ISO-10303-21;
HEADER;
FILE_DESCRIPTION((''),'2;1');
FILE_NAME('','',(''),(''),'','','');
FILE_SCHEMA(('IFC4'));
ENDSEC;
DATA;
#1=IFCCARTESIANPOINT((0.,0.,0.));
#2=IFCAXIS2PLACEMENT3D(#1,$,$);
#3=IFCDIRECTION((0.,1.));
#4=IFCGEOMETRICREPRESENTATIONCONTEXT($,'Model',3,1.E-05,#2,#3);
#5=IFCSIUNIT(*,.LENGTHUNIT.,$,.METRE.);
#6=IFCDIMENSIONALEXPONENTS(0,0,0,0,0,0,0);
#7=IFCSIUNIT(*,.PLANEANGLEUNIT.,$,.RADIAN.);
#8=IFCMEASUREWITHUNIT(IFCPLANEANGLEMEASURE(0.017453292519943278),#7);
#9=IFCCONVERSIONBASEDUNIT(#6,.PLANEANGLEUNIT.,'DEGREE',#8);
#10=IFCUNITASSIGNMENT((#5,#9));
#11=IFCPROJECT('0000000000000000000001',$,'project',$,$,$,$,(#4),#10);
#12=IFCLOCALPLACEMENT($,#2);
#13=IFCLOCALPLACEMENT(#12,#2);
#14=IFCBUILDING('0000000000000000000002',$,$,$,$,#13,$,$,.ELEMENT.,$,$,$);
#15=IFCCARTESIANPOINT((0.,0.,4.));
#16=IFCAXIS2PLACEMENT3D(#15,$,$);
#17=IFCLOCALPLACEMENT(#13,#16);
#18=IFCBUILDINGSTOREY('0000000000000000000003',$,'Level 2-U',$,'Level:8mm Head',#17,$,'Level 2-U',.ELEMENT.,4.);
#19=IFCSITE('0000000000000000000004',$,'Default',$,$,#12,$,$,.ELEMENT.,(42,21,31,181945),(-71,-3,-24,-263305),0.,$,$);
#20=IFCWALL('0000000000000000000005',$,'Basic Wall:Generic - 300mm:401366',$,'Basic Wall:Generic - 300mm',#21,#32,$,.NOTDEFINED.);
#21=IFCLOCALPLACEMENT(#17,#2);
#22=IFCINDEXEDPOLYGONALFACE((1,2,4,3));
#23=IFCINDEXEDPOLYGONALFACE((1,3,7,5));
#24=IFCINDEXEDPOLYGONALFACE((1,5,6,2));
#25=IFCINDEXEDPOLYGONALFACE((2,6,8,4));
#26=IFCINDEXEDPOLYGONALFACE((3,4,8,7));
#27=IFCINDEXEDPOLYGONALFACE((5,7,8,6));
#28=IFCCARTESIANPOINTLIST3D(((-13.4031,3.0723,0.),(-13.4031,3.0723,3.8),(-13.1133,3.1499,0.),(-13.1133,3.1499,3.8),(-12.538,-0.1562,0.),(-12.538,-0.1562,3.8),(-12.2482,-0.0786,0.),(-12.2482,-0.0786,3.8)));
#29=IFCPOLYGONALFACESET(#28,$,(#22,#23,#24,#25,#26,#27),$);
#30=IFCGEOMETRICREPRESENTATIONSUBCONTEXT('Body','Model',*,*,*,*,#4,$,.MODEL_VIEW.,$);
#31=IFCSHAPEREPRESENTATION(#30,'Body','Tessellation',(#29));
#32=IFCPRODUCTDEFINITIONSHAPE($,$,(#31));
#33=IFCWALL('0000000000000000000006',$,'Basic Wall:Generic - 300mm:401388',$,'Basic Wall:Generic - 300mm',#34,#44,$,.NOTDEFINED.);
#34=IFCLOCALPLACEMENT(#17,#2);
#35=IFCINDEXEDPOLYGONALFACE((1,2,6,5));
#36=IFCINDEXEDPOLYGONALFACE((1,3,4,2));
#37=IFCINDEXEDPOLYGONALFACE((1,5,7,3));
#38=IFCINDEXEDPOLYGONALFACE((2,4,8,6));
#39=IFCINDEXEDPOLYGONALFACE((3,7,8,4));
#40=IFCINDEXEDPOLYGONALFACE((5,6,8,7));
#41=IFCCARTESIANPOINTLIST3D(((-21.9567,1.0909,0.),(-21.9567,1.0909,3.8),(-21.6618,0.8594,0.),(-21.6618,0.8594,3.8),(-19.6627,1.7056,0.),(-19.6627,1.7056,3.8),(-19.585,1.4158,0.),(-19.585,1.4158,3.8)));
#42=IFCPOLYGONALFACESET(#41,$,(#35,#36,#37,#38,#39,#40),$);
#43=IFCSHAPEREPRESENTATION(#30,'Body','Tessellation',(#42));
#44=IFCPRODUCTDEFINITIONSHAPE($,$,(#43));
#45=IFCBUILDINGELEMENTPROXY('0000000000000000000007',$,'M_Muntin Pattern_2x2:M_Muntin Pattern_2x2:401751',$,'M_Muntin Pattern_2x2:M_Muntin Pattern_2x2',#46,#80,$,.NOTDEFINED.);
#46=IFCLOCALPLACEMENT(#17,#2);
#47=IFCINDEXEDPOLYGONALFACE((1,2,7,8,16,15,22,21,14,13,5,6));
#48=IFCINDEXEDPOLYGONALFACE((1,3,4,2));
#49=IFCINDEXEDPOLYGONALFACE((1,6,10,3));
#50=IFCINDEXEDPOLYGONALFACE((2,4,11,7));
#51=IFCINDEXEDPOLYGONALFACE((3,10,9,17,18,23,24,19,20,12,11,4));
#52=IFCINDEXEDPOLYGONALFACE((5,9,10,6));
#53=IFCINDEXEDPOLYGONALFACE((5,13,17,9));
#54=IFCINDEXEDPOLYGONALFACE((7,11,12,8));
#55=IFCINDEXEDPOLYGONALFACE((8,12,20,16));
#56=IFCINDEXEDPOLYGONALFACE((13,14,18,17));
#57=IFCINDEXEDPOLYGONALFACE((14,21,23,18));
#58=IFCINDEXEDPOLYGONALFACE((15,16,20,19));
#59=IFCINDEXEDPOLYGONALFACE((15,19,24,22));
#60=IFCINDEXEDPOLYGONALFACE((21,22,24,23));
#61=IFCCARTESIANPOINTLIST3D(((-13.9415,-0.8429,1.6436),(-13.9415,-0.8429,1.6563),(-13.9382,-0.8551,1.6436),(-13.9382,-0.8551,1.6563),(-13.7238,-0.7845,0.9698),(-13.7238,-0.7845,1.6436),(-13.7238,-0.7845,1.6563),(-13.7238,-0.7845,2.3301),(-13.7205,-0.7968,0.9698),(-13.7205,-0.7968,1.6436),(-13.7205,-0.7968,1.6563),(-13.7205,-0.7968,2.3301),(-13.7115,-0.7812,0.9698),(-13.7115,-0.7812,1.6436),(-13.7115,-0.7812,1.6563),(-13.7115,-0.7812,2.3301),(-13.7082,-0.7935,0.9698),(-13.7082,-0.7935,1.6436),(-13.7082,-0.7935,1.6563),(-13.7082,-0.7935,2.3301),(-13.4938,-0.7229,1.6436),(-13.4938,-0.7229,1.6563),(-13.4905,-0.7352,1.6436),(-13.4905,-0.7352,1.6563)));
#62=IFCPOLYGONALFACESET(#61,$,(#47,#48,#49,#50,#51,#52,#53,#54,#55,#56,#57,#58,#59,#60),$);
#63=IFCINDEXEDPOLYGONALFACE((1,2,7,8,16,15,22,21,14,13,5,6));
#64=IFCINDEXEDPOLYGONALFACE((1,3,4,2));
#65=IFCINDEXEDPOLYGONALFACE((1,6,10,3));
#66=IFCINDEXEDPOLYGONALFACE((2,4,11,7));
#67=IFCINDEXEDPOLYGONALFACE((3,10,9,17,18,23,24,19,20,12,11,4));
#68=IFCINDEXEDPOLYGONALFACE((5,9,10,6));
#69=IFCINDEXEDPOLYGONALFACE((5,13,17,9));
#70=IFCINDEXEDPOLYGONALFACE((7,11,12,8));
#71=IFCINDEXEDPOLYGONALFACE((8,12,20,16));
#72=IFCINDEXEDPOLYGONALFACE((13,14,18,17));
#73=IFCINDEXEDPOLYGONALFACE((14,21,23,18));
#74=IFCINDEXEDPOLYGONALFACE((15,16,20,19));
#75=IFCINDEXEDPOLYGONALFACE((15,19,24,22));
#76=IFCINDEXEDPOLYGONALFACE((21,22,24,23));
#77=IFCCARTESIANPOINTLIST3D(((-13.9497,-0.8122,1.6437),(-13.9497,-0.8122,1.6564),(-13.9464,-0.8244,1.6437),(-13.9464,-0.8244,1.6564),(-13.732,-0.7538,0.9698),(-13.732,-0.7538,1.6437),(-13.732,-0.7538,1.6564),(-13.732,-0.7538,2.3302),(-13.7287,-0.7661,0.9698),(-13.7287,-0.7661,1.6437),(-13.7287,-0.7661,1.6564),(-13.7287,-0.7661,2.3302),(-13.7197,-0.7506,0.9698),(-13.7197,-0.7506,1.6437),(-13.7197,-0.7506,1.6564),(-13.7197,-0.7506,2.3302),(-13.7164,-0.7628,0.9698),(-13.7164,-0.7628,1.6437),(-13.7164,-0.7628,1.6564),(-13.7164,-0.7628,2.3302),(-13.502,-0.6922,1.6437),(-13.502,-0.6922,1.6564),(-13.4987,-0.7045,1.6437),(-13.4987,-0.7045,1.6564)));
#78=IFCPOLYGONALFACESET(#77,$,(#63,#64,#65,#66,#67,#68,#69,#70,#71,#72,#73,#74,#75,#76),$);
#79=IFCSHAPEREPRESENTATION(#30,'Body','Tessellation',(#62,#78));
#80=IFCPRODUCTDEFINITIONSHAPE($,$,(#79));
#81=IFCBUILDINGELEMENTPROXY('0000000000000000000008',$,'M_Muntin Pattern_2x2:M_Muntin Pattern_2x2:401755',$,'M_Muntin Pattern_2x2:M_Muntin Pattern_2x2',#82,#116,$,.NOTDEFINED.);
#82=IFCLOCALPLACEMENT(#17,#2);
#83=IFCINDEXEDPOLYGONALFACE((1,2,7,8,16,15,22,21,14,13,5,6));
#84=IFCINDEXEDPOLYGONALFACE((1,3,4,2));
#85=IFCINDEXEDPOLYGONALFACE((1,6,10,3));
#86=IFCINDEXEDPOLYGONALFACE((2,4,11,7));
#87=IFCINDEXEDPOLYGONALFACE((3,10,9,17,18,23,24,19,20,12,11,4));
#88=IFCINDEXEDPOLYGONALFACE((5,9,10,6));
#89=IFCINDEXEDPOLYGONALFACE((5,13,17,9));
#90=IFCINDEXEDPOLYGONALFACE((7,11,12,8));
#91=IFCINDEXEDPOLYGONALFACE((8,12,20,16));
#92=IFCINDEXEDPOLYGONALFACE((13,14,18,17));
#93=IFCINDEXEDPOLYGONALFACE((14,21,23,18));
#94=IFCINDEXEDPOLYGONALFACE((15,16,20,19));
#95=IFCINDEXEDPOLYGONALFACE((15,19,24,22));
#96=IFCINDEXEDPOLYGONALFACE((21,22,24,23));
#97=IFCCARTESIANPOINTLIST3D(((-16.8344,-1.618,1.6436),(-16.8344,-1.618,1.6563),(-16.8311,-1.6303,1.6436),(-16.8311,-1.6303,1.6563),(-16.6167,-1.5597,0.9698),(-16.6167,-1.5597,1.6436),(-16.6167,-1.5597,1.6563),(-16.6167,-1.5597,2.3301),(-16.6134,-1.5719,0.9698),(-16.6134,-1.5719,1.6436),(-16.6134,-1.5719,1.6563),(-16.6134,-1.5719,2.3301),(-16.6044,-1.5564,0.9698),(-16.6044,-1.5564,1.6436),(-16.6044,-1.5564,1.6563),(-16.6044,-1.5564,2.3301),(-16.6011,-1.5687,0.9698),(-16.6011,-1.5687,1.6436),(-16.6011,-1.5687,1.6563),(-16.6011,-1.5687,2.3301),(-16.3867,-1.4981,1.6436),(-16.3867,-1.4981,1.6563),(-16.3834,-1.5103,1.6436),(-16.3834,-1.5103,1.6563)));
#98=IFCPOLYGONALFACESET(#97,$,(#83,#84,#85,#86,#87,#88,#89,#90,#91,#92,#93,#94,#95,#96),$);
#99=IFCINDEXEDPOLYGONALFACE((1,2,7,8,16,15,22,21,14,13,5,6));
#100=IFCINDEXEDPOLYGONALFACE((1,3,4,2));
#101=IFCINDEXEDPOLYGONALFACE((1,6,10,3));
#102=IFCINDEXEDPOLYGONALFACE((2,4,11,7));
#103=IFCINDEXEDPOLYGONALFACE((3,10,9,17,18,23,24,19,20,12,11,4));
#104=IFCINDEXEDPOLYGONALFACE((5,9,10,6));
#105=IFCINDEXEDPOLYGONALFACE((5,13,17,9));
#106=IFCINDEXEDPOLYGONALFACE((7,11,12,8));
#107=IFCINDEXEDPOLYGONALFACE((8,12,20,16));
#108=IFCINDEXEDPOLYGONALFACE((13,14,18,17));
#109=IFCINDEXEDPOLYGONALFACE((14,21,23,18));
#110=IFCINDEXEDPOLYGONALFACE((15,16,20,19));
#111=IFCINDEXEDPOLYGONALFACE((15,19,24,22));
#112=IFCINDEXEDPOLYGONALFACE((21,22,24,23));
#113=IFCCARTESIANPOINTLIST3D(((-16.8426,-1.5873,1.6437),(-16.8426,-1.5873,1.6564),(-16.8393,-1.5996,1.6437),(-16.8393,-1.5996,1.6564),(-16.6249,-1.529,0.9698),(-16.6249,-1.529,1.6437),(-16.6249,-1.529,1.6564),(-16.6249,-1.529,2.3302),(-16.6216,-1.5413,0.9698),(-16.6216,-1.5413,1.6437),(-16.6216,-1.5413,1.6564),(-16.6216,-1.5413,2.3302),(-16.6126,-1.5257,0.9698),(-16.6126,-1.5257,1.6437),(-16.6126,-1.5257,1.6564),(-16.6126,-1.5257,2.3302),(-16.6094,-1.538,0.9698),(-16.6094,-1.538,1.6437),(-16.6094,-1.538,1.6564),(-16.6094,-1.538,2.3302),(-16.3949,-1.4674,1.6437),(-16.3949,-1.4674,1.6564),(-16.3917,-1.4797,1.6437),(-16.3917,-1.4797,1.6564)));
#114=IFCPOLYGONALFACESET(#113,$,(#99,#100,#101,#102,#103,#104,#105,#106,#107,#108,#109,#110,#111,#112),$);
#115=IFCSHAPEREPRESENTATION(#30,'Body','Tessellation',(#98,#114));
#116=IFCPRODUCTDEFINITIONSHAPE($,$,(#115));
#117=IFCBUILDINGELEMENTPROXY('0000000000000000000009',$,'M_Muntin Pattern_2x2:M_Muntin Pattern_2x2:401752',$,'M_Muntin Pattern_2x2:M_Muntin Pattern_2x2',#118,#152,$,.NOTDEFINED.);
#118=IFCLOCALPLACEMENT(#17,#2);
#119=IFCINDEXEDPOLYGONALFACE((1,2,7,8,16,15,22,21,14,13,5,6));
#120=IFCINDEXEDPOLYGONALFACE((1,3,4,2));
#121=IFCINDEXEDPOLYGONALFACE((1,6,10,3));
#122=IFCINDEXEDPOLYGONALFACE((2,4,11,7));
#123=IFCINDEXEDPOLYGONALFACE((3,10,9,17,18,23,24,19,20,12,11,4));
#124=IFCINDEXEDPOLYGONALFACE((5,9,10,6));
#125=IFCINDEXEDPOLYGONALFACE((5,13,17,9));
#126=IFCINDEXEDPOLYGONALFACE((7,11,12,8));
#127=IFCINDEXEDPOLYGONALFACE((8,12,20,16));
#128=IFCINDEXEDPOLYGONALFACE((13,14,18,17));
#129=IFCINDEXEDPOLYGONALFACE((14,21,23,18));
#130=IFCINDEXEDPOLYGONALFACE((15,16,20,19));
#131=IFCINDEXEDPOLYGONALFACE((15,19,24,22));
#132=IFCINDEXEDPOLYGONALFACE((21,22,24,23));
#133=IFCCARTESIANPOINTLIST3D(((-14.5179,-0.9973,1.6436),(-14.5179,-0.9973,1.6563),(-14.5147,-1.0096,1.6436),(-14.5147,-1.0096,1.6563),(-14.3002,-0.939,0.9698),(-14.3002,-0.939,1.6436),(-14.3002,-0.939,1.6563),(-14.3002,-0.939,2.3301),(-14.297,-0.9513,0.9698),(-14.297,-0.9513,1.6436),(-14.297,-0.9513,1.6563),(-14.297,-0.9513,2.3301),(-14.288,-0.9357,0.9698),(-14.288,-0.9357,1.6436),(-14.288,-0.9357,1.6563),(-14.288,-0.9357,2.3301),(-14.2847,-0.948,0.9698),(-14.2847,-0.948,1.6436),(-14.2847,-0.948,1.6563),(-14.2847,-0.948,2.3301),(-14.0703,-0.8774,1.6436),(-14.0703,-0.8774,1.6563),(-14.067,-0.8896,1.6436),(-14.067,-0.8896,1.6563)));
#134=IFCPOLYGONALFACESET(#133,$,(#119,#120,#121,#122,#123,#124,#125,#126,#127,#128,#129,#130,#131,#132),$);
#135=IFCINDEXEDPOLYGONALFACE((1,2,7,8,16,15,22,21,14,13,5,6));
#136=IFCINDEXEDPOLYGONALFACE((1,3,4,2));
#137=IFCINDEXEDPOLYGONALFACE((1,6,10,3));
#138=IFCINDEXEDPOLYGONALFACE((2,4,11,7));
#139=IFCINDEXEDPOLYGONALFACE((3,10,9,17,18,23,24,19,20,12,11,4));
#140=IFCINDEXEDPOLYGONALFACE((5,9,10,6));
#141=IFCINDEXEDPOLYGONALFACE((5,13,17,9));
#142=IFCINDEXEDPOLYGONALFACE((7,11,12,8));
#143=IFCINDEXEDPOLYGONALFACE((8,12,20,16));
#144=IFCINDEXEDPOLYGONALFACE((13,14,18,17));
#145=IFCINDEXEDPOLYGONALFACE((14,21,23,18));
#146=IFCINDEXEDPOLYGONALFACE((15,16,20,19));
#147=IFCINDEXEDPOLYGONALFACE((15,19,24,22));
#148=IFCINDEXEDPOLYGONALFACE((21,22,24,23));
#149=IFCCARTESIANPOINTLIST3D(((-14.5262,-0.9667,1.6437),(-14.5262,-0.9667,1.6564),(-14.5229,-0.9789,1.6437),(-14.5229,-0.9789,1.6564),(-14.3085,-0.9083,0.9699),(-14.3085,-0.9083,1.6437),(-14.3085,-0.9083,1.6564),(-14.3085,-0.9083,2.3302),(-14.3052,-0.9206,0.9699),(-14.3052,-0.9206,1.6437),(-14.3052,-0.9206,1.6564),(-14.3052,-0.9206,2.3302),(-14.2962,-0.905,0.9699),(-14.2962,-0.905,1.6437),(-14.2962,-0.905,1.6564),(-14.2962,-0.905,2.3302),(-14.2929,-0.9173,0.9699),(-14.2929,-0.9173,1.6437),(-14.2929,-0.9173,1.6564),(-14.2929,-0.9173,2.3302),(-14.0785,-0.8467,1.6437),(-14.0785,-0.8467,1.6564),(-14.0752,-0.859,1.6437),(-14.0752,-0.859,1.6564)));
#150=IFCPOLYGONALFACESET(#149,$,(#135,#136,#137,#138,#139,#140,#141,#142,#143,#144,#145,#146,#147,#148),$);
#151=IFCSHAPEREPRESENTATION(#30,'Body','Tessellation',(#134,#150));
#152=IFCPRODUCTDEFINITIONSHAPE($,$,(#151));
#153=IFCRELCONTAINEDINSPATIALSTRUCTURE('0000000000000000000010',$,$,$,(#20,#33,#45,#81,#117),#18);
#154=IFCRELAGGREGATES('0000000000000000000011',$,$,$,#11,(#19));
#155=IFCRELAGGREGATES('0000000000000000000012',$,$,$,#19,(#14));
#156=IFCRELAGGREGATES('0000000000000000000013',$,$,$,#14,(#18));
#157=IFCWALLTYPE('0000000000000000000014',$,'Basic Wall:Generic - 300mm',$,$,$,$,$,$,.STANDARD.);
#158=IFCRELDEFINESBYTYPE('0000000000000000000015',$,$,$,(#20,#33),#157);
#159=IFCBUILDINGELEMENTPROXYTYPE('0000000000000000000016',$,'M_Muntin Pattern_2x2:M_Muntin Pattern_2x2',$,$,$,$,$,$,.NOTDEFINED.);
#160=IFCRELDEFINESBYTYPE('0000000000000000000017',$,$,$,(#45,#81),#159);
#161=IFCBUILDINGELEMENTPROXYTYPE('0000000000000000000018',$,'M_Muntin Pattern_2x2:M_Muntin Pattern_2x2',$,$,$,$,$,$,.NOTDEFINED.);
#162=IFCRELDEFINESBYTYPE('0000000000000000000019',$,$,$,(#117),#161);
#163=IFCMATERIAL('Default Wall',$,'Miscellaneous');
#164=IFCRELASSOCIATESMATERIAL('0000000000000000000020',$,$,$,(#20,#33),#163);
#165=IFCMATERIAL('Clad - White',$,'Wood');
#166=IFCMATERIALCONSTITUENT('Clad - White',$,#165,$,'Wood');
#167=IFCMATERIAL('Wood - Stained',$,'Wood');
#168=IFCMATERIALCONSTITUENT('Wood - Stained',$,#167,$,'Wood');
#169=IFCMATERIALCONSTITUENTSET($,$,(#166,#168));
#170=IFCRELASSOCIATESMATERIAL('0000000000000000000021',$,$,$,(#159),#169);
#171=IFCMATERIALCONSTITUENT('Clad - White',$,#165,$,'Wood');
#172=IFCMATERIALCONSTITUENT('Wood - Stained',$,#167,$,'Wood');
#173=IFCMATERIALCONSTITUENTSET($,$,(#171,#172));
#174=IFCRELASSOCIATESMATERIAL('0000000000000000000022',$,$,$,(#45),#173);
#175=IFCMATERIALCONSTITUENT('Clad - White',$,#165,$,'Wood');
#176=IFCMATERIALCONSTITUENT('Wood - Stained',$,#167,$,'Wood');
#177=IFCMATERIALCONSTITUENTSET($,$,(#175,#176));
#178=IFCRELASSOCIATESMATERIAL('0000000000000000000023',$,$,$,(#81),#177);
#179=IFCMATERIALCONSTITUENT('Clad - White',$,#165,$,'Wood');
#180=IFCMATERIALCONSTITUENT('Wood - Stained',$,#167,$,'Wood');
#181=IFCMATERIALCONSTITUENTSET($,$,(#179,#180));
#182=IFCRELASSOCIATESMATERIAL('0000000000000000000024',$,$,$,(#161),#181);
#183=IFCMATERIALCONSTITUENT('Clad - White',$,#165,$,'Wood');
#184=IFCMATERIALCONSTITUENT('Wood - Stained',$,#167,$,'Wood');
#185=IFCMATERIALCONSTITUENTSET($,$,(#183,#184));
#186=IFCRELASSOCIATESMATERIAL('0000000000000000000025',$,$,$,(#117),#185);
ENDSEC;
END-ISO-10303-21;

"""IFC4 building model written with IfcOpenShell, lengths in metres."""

from ifc_helpers import new_model, entity, si_unit, converted_unit, direction, frame, origin, place, context, subcontext, project, spatial, indexed_curve, outline, extrude, source, transform, mapped, material, constituent, constituent_set, type_object, type_shapes, element, save


model = new_model("IFC4")

# Units and contexts
model_context = context("Model", 3, precision=1e-05, world=origin(), true_north=direction((0.0, 1.0)))
body_context = subcontext(model_context, "Body", "Model", "MODEL_VIEW")
ifc_project = project(units=[si_unit("LENGTHUNIT", "METRE"), converted_unit("PLANEANGLEUNIT", "DEGREE", entity("IfcPlaneAngleMeasure", 0.017453292519943278), si_unit("PLANEANGLEUNIT", "RADIAN"), dimensions=[0, 0, 0, 0, 0, 0, 0])], contexts=[model_context])

# Site, building, storey
site_placement = place(None, origin())
site = spatial("IfcSite", under=ifc_project, at=site_placement, Name="Default", CompositionType="ELEMENT", RefLatitude=(42, 21, 31, 181945), RefLongitude=(-71, -3, -24, -263305), RefElevation=0.0)
building_placement = place(site_placement, origin())
building = spatial("IfcBuilding", under=site, at=building_placement, CompositionType="ELEMENT")
storey_placement = place(building_placement, frame((0.0, 0.0, 4.0)))
storey = spatial("IfcBuildingStorey", under=building, at=storey_placement, Name="Level 2-U", ObjectType="Level:8mm Head", LongName="Level 2-U", CompositionType="ELEMENT", Elevation=4.0)

# Walls
ifc_material_1 = material(Name="Default Wall", Category="Miscellaneous")
wall_type = type_object("IfcWallType", Name="Basic Wall:Generic - 300mm", PredefinedType="STANDARD")
wall_1_placement = place(storey_placement, frame((-13.2582, 3.1111, 0.0), z_axis=(0.0, 0.0, 1.0), x_axis=(0.258819, -0.965926, 0.0)))
element("IfcWall", 1, at=wall_1_placement, inside=storey, type_object=wall_type, material=ifc_material_1, Name="Basic Wall:Generic - 300mm:401366", ObjectType="Basic Wall:Generic - 300mm", PredefinedType="NOTDEFINED", context=body_context, shape_type="SweptSolid", body=[
    extrude(outline(indexed_curve([(3.3424, 0.15), (0.0, 0.15), (0.0, -0.15), (3.3424, -0.15), (3.3424, 0.15)], self_intersect=False)), origin(), (0.0, 0.0, 1.0), 3.8),
])
wall_2_placement = place(storey_placement, frame((-19.6238, 1.5607, 0.0), z_axis=(0.0, 0.0, 1.0), x_axis=(-0.965926, -0.258819, 0.0)))
element("IfcWall", 2, at=wall_2_placement, inside=storey, type_object=wall_type, material=ifc_material_1, Name="Basic Wall:Generic - 300mm:401388", ObjectType="Basic Wall:Generic - 300mm", PredefinedType="NOTDEFINED", context=body_context, shape_type="SweptSolid", body=[
    extrude(outline(indexed_curve([(2.375, -0.15), (2.15, 0.15), (0.0, 0.15), (0.0, -0.15), (2.375, -0.15)], self_intersect=False)), origin(), (0.0, 0.0, 1.0), 3.8),
])

# Building element proxies
ifc_material_2 = material(Name="Clad - White", Category="Wood")
ifc_constituent_1 = constituent(ifc_material_2, Name="Clad - White", Category="Wood")
ifc_material_3 = material(Name="Wood - Stained", Category="Wood")
ifc_constituent_2 = constituent(ifc_material_3, Name="Wood - Stained", Category="Wood")
ifc_constituent_set_1 = constituent_set(constituents=[ifc_constituent_1, ifc_constituent_2])
ifc_constituent_3 = constituent(ifc_material_2, Name="Clad - White", Category="Wood")
ifc_constituent_4 = constituent(ifc_material_3, Name="Wood - Stained", Category="Wood")
ifc_constituent_set_2 = constituent_set(constituents=[ifc_constituent_3, ifc_constituent_4])
building_element_proxy_type_1 = type_object("IfcBuildingElementProxyType", Name="M_Muntin Pattern_2x2:M_Muntin Pattern_2x2", PredefinedType="NOTDEFINED", material=ifc_constituent_set_2)
shared_shape_1 = source(origin(), body_context, "Body", "SweptSolid", [
    extrude(outline(indexed_curve([(0.0064, -0.0064), (0.6801, -0.0064), (0.6801, 0.0063), (0.0064, 0.0063), (0.0064, 0.2317), (-0.0063, 0.2317), (-0.0063, 0.0063), (-0.6802, 0.0063), (-0.6802, -0.0064), (-0.0063, -0.0064), (-0.0063, -0.2317), (0.0064, -0.2317), (0.0064, -0.0064)], self_intersect=False)), frame((0.0, 0.0095, 0.6801), z_axis=(0.0, 1.0, 0.0), x_axis=(0.0, 0.0, 1.0)), (0.0, 0.0, 1.0), 0.0127),
    extrude(outline(indexed_curve([(0.0064, -0.0064), (0.6802, -0.0064), (0.6802, 0.0063), (0.0064, 0.0063), (0.0064, 0.2317), (-0.0063, 0.2317), (-0.0063, 0.0063), (-0.6802, 0.0063), (-0.6802, -0.0064), (-0.0063, -0.0064), (-0.0063, -0.2317), (0.0064, -0.2317), (0.0064, -0.0064)], self_intersect=False)), frame((0.0, -0.0222, 0.6802), z_axis=(0.0, 1.0, 0.0), x_axis=(0.0, 0.0, 1.0)), (0.0, 0.0, 1.0), 0.0127),
])
type_shapes(building_element_proxy_type_1, [shared_shape_1])
proxy_1_placement = place(storey_placement, frame((-13.7201, -0.7737, 0.9698), z_axis=(0.0, 0.0, 1.0), x_axis=(-0.965926, -0.258819, 0.0)))
element("IfcBuildingElementProxy", 3, at=proxy_1_placement, inside=storey, type_object=building_element_proxy_type_1, material=ifc_constituent_set_1, Name="M_Muntin Pattern_2x2:M_Muntin Pattern_2x2:401751", ObjectType="M_Muntin Pattern_2x2:M_Muntin Pattern_2x2", PredefinedType="NOTDEFINED", context=body_context, shape_type="MappedRepresentation", body=[
    mapped(shared_shape_1, transform((0.0, 0.0, 0.0), scale=1.0)),
])
ifc_constituent_5 = constituent(ifc_material_2, Name="Clad - White", Category="Wood")
ifc_constituent_6 = constituent(ifc_material_3, Name="Wood - Stained", Category="Wood")
ifc_constituent_set_3 = constituent_set(constituents=[ifc_constituent_5, ifc_constituent_6])
proxy_2_placement = place(storey_placement, frame((-16.613, -1.5488, 0.9698), z_axis=(0.0, 0.0, 1.0), x_axis=(-0.965926, -0.258819, 0.0)))
element("IfcBuildingElementProxy", 4, at=proxy_2_placement, inside=storey, type_object=building_element_proxy_type_1, material=ifc_constituent_set_3, Name="M_Muntin Pattern_2x2:M_Muntin Pattern_2x2:401755", ObjectType="M_Muntin Pattern_2x2:M_Muntin Pattern_2x2", PredefinedType="NOTDEFINED", context=body_context, shape_type="MappedRepresentation", body=[
    mapped(shared_shape_1, transform((0.0, 0.0, 0.0), scale=1.0)),
])
ifc_constituent_7 = constituent(ifc_material_2, Name="Clad - White", Category="Wood")
ifc_constituent_8 = constituent(ifc_material_3, Name="Wood - Stained", Category="Wood")
ifc_constituent_set_4 = constituent_set(constituents=[ifc_constituent_7, ifc_constituent_8])
ifc_constituent_9 = constituent(ifc_material_2, Name="Clad - White", Category="Wood")
ifc_constituent_10 = constituent(ifc_material_3, Name="Wood - Stained", Category="Wood")
ifc_constituent_set_5 = constituent_set(constituents=[ifc_constituent_9, ifc_constituent_10])
building_element_proxy_type_2 = type_object("IfcBuildingElementProxyType", Name="M_Muntin Pattern_2x2:M_Muntin Pattern_2x2", PredefinedType="NOTDEFINED", material=ifc_constituent_set_5)
shared_shape_2 = source(origin(), body_context, "Body", "SweptSolid", [
    extrude(outline(indexed_curve([(0.0064, -0.0064), (0.6801, -0.0064), (0.6801, 0.0063), (0.0064, 0.0063), (0.0064, 0.2317), (-0.0063, 0.2317), (-0.0063, 0.0063), (-0.6802, 0.0063), (-0.6802, -0.0064), (-0.0063, -0.0064), (-0.0063, -0.2317), (0.0064, -0.2317), (0.0064, -0.0064)], self_intersect=False)), frame((0.0, -0.0222, 0.6801), z_axis=(0.0, 1.0, 0.0), x_axis=(0.0, 0.0, 1.0)), (0.0, 0.0, 1.0), 0.0127),
    extrude(outline(indexed_curve([(0.0064, -0.0064), (0.6802, -0.0064), (0.6802, 0.0063), (0.0064, 0.0063), (0.0064, 0.2317), (-0.0063, 0.2317), (-0.0063, 0.0063), (-0.6802, 0.0063), (-0.6802, -0.0064), (-0.0063, -0.0064), (-0.0063, -0.2317), (0.0064, -0.2317), (0.0064, -0.0064)], self_intersect=False)), frame((0.0, 0.0095, 0.6802), z_axis=(0.0, 1.0, 0.0), x_axis=(0.0, 0.0, 1.0)), (0.0, 0.0, 1.0), 0.0127),
])
type_shapes(building_element_proxy_type_2, [shared_shape_2])
proxy_3_placement = place(storey_placement, frame((-14.2966, -0.9281, 0.9699), z_axis=(0.0, 0.0, 1.0), x_axis=(0.965926, 0.258819, 0.0)))
element("IfcBuildingElementProxy", 5, at=proxy_3_placement, inside=storey, type_object=building_element_proxy_type_2, material=ifc_constituent_set_4, Name="M_Muntin Pattern_2x2:M_Muntin Pattern_2x2:401752", ObjectType="M_Muntin Pattern_2x2:M_Muntin Pattern_2x2", PredefinedType="NOTDEFINED", context=body_context, shape_type="MappedRepresentation", body=[
    mapped(shared_shape_2, transform((0.0, 0.0, 0.0), scale=1.0)),
])

save(model, "model.ifc")
